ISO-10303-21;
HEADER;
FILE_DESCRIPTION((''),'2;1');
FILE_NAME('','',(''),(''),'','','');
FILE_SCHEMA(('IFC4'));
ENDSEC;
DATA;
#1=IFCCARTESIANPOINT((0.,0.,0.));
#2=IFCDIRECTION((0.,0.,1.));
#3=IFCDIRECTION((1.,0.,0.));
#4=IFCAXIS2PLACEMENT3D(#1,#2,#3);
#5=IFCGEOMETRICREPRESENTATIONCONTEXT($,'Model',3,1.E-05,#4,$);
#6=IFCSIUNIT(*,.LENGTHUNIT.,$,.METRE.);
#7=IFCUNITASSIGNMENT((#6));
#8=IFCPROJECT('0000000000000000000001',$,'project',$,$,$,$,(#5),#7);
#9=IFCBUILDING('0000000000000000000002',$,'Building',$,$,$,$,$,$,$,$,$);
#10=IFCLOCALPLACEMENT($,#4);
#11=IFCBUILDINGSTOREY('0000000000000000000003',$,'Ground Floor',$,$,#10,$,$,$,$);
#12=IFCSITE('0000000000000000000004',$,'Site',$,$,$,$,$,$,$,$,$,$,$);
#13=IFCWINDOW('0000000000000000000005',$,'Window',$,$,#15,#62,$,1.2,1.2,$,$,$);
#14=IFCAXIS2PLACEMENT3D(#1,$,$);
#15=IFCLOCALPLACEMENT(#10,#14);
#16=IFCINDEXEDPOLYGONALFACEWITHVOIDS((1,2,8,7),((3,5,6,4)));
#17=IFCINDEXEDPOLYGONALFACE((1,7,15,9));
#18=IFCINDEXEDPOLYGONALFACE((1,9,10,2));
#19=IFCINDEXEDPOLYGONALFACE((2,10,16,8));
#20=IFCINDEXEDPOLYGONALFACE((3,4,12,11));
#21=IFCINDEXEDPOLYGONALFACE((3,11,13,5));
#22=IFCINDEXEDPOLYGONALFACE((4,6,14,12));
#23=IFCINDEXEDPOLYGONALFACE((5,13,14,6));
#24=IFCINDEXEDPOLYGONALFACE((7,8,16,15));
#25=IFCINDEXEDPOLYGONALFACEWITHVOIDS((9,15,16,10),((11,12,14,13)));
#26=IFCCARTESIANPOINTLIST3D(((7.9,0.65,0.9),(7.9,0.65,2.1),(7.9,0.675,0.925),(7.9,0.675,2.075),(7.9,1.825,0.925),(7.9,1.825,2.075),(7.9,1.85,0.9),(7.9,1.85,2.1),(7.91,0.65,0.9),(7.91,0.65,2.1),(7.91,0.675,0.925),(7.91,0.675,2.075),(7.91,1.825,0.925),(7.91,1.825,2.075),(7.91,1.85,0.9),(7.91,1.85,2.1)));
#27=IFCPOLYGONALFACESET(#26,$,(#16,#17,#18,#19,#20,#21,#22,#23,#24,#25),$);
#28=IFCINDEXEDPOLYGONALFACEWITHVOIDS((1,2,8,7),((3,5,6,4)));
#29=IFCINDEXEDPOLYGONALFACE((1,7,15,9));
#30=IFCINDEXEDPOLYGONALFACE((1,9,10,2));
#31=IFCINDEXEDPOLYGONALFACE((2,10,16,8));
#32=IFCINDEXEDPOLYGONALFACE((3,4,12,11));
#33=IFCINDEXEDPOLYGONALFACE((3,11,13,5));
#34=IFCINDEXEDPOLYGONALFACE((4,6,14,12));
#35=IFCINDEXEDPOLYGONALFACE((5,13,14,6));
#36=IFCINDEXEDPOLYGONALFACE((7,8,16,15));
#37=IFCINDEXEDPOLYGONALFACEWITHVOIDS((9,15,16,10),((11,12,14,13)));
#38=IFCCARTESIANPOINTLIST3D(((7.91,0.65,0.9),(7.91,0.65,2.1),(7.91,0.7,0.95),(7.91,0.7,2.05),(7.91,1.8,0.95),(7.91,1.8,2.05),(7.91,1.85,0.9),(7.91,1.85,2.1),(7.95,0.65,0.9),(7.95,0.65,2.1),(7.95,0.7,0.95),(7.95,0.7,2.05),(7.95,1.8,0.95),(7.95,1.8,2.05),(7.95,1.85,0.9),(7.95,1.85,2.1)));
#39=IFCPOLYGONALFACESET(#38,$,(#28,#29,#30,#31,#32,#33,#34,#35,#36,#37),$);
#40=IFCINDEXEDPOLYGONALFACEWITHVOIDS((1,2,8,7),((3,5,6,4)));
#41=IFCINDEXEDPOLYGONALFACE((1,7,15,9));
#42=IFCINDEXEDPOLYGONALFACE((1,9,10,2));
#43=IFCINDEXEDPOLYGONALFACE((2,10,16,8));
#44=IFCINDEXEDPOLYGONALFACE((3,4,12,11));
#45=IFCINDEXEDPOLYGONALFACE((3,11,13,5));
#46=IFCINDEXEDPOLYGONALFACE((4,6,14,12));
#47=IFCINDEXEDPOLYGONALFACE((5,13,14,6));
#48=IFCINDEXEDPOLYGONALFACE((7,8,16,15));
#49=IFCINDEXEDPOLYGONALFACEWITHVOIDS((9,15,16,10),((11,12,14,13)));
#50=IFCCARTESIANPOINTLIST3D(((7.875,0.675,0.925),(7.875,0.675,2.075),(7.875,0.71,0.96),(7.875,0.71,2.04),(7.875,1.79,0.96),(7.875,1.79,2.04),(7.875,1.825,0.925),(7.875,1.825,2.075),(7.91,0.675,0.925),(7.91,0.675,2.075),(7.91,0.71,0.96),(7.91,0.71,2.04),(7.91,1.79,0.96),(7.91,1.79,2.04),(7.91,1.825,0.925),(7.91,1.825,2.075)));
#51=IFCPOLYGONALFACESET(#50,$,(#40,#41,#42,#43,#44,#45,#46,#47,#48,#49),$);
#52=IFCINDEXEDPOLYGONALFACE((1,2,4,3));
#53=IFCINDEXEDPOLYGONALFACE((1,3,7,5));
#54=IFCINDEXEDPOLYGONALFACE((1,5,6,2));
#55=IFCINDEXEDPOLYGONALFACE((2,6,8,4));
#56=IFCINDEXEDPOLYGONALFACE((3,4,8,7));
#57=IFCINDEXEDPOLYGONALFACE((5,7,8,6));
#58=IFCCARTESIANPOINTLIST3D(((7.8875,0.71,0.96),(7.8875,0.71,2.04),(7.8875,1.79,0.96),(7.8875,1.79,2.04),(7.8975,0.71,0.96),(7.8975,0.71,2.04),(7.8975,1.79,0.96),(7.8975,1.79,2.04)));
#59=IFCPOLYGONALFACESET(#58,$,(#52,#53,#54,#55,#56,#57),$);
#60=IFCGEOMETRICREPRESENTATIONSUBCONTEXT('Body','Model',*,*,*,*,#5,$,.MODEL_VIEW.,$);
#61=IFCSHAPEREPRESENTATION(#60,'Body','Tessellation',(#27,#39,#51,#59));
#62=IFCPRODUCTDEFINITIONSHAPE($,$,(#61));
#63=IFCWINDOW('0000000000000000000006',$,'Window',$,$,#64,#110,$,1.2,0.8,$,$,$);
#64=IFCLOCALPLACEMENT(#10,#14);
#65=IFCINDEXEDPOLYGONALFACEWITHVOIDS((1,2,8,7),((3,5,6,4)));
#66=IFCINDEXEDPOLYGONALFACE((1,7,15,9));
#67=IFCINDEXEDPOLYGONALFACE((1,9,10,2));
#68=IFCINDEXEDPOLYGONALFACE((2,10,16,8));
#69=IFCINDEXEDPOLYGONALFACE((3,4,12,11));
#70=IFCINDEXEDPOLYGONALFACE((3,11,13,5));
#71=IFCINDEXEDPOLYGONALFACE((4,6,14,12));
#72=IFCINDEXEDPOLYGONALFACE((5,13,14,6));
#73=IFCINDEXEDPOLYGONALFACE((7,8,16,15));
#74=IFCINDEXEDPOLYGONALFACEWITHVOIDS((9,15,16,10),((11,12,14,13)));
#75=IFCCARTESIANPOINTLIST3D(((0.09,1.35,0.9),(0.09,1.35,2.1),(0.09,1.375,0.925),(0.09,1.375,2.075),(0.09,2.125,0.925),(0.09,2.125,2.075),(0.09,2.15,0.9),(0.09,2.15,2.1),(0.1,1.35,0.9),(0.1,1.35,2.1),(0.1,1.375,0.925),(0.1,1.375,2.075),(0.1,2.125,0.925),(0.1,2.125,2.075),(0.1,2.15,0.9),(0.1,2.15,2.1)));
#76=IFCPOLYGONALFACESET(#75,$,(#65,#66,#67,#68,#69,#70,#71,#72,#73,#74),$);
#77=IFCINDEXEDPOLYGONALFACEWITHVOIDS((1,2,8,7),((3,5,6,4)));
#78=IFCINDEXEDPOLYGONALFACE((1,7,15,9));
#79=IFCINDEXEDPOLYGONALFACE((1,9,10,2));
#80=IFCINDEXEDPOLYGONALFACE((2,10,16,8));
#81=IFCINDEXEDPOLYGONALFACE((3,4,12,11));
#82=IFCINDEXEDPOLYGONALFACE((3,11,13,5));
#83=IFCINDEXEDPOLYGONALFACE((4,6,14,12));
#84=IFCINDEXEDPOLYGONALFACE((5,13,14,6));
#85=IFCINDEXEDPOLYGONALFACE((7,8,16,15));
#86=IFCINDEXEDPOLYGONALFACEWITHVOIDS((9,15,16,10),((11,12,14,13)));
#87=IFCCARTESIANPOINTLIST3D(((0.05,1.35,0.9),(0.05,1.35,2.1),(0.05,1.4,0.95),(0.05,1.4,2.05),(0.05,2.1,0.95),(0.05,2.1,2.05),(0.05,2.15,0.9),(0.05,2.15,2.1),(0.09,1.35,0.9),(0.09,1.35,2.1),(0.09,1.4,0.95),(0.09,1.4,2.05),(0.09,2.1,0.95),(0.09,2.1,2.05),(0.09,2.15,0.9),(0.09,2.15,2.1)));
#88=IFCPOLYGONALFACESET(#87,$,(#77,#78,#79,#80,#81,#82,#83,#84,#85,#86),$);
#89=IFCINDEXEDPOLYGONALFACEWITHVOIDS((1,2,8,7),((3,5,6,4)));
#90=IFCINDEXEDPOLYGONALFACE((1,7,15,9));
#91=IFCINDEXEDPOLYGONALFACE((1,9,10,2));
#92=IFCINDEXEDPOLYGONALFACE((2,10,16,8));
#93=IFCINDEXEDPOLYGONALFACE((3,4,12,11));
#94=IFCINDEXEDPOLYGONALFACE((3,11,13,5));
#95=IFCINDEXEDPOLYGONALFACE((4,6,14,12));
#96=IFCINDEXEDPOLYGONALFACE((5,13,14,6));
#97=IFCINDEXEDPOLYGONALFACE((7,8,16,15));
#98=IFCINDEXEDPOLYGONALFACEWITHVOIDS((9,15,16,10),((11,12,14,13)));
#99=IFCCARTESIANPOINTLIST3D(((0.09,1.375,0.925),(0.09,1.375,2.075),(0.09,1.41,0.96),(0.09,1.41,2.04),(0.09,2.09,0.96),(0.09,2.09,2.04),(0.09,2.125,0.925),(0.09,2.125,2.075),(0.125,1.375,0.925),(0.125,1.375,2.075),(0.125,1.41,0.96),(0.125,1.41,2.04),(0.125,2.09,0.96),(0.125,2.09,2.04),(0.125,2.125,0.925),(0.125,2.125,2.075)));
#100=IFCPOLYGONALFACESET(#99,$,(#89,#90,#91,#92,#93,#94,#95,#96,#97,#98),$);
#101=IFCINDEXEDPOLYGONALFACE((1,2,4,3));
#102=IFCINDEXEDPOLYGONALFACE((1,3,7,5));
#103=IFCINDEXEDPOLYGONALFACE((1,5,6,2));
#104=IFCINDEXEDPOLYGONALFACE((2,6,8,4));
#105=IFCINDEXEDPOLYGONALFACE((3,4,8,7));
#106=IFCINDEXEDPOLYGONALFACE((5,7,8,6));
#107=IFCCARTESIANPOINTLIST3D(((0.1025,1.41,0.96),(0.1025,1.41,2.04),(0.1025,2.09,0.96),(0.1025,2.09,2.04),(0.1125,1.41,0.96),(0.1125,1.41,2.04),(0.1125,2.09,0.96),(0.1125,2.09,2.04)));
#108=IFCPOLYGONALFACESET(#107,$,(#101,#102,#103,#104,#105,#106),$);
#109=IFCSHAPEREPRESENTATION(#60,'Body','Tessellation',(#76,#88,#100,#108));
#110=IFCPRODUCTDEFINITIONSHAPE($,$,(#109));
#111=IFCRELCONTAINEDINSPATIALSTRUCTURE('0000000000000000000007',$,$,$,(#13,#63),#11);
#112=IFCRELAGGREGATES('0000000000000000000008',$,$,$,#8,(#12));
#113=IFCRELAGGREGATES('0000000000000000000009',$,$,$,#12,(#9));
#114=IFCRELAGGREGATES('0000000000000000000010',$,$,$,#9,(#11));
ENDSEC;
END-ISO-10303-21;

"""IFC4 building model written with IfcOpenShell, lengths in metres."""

from ifc_helpers import new_model, si_unit, frame, origin_with_axes, place, context, subcontext, project, spatial, line, indexed_curve, outline, extrude, element, save


model = new_model("IFC4")

# Units and contexts
model_context = context("Model", 3, precision=1e-05, world=origin_with_axes())
body_context = subcontext(model_context, "Body", "Model", "MODEL_VIEW")
ifc_project = project(units=[si_unit("LENGTHUNIT", "METRE")], contexts=[model_context])

# Site, building, storey
site = spatial("IfcSite", under=ifc_project, Name="Site")
building = spatial("IfcBuilding", under=site, Name="Building")
storey_placement = place(None, origin_with_axes())
storey = spatial("IfcBuildingStorey", under=building, at=storey_placement, Name="Ground Floor")

# Windows
window_1_placement = place(storey_placement, frame((8.0, 0.65, 0.9), z_axis=(0.0, 0.0, 1.0), x_axis=(0.0, 1.0, 0.0)))
element("IfcWindow", 1, at=window_1_placement, inside=storey, Name="Window", OverallHeight=1.2, OverallWidth=1.2, context=body_context, shape_type="SweptSolid", body=[
    extrude(outline(indexed_curve([(0.0, 0.0), (1.2, 0.0), (1.2, 1.2), (0.0, 1.2)], segments=[line(1, 2, 3, 4, 1)]), holes=[indexed_curve([(0.025, 0.025), (1.175, 0.025), (1.175, 1.175), (0.025, 1.175)], segments=[line(1, 2, 3, 4, 1)])]), frame((0.0, 0.09, 0.0), z_axis=(0.0, -1.0, 0.0), x_axis=(1.0, 0.0, 0.0)), (0.0, 0.0, -1.0), 0.01),
    extrude(outline(indexed_curve([(0.0, 0.0), (1.2, 0.0), (1.2, 1.2), (0.0, 1.2)], segments=[line(1, 2, 3, 4, 1)]), holes=[indexed_curve([(0.05, 0.05), (1.15, 0.05), (1.15, 1.15), (0.05, 1.15)], segments=[line(1, 2, 3, 4, 1)])]), frame((0.0, 0.05, 0.0), z_axis=(0.0, -1.0, 0.0), x_axis=(1.0, 0.0, 0.0)), (0.0, 0.0, -1.0), 0.04),
    extrude(outline(indexed_curve([(0.0, 0.0), (1.15, 0.0), (1.15, 1.15), (0.0, 1.15)], segments=[line(1, 2, 3, 4, 1)]), holes=[indexed_curve([(0.035, 0.035), (1.115, 0.035), (1.115, 1.115), (0.035, 1.115)], segments=[line(1, 2, 3, 4, 1)])]), frame((0.025, 0.09, 0.025), z_axis=(0.0, -1.0, 0.0), x_axis=(1.0, 0.0, 0.0)), (0.0, 0.0, -1.0), 0.035),
    extrude(outline(indexed_curve([(0.035, 0.035), (1.115, 0.035), (1.115, 1.115), (0.035, 1.115)], segments=[line(1, 2, 3, 4, 1)])), frame((0.025, 0.1025, 0.025), z_axis=(0.0, -1.0, 0.0), x_axis=(1.0, 0.0, 0.0)), (0.0, 0.0, -1.0), 0.01),
])
window_2_placement = place(storey_placement, frame((0.0, 2.15, 0.9), z_axis=(0.0, 0.0, 1.0), x_axis=(0.0, -1.0, 0.0)))
element("IfcWindow", 2, at=window_2_placement, inside=storey, Name="Window", OverallHeight=1.2, OverallWidth=0.8, context=body_context, shape_type="SweptSolid", body=[
    extrude(outline(indexed_curve([(0.0, 0.0), (0.8, 0.0), (0.8, 1.2), (0.0, 1.2)], segments=[line(1, 2, 3, 4, 1)]), holes=[indexed_curve([(0.025, 0.025), (0.775, 0.025), (0.775, 1.175), (0.025, 1.175)], segments=[line(1, 2, 3, 4, 1)])]), frame((0.0, 0.09, 0.0), z_axis=(0.0, -1.0, 0.0), x_axis=(1.0, 0.0, 0.0)), (0.0, 0.0, -1.0), 0.01),
    extrude(outline(indexed_curve([(0.0, 0.0), (0.8, 0.0), (0.8, 1.2), (0.0, 1.2)], segments=[line(1, 2, 3, 4, 1)]), holes=[indexed_curve([(0.05, 0.05), (0.75, 0.05), (0.75, 1.15), (0.05, 1.15)], segments=[line(1, 2, 3, 4, 1)])]), frame((0.0, 0.05, 0.0), z_axis=(0.0, -1.0, 0.0), x_axis=(1.0, 0.0, 0.0)), (0.0, 0.0, -1.0), 0.04),
    extrude(outline(indexed_curve([(0.0, 0.0), (0.75, 0.0), (0.75, 1.15), (0.0, 1.15)], segments=[line(1, 2, 3, 4, 1)]), holes=[indexed_curve([(0.035, 0.035), (0.715, 0.035), (0.715, 1.115), (0.035, 1.115)], segments=[line(1, 2, 3, 4, 1)])]), frame((0.025, 0.09, 0.025), z_axis=(0.0, -1.0, 0.0), x_axis=(1.0, 0.0, 0.0)), (0.0, 0.0, -1.0), 0.035),
    extrude(outline(indexed_curve([(0.035, 0.035), (0.715, 0.035), (0.715, 1.115), (0.035, 1.115)], segments=[line(1, 2, 3, 4, 1)])), frame((0.025, 0.1025, 0.025), z_axis=(0.0, -1.0, 0.0), x_axis=(1.0, 0.0, 0.0)), (0.0, 0.0, -1.0), 0.01),
])

save(model, "model.ifc")
